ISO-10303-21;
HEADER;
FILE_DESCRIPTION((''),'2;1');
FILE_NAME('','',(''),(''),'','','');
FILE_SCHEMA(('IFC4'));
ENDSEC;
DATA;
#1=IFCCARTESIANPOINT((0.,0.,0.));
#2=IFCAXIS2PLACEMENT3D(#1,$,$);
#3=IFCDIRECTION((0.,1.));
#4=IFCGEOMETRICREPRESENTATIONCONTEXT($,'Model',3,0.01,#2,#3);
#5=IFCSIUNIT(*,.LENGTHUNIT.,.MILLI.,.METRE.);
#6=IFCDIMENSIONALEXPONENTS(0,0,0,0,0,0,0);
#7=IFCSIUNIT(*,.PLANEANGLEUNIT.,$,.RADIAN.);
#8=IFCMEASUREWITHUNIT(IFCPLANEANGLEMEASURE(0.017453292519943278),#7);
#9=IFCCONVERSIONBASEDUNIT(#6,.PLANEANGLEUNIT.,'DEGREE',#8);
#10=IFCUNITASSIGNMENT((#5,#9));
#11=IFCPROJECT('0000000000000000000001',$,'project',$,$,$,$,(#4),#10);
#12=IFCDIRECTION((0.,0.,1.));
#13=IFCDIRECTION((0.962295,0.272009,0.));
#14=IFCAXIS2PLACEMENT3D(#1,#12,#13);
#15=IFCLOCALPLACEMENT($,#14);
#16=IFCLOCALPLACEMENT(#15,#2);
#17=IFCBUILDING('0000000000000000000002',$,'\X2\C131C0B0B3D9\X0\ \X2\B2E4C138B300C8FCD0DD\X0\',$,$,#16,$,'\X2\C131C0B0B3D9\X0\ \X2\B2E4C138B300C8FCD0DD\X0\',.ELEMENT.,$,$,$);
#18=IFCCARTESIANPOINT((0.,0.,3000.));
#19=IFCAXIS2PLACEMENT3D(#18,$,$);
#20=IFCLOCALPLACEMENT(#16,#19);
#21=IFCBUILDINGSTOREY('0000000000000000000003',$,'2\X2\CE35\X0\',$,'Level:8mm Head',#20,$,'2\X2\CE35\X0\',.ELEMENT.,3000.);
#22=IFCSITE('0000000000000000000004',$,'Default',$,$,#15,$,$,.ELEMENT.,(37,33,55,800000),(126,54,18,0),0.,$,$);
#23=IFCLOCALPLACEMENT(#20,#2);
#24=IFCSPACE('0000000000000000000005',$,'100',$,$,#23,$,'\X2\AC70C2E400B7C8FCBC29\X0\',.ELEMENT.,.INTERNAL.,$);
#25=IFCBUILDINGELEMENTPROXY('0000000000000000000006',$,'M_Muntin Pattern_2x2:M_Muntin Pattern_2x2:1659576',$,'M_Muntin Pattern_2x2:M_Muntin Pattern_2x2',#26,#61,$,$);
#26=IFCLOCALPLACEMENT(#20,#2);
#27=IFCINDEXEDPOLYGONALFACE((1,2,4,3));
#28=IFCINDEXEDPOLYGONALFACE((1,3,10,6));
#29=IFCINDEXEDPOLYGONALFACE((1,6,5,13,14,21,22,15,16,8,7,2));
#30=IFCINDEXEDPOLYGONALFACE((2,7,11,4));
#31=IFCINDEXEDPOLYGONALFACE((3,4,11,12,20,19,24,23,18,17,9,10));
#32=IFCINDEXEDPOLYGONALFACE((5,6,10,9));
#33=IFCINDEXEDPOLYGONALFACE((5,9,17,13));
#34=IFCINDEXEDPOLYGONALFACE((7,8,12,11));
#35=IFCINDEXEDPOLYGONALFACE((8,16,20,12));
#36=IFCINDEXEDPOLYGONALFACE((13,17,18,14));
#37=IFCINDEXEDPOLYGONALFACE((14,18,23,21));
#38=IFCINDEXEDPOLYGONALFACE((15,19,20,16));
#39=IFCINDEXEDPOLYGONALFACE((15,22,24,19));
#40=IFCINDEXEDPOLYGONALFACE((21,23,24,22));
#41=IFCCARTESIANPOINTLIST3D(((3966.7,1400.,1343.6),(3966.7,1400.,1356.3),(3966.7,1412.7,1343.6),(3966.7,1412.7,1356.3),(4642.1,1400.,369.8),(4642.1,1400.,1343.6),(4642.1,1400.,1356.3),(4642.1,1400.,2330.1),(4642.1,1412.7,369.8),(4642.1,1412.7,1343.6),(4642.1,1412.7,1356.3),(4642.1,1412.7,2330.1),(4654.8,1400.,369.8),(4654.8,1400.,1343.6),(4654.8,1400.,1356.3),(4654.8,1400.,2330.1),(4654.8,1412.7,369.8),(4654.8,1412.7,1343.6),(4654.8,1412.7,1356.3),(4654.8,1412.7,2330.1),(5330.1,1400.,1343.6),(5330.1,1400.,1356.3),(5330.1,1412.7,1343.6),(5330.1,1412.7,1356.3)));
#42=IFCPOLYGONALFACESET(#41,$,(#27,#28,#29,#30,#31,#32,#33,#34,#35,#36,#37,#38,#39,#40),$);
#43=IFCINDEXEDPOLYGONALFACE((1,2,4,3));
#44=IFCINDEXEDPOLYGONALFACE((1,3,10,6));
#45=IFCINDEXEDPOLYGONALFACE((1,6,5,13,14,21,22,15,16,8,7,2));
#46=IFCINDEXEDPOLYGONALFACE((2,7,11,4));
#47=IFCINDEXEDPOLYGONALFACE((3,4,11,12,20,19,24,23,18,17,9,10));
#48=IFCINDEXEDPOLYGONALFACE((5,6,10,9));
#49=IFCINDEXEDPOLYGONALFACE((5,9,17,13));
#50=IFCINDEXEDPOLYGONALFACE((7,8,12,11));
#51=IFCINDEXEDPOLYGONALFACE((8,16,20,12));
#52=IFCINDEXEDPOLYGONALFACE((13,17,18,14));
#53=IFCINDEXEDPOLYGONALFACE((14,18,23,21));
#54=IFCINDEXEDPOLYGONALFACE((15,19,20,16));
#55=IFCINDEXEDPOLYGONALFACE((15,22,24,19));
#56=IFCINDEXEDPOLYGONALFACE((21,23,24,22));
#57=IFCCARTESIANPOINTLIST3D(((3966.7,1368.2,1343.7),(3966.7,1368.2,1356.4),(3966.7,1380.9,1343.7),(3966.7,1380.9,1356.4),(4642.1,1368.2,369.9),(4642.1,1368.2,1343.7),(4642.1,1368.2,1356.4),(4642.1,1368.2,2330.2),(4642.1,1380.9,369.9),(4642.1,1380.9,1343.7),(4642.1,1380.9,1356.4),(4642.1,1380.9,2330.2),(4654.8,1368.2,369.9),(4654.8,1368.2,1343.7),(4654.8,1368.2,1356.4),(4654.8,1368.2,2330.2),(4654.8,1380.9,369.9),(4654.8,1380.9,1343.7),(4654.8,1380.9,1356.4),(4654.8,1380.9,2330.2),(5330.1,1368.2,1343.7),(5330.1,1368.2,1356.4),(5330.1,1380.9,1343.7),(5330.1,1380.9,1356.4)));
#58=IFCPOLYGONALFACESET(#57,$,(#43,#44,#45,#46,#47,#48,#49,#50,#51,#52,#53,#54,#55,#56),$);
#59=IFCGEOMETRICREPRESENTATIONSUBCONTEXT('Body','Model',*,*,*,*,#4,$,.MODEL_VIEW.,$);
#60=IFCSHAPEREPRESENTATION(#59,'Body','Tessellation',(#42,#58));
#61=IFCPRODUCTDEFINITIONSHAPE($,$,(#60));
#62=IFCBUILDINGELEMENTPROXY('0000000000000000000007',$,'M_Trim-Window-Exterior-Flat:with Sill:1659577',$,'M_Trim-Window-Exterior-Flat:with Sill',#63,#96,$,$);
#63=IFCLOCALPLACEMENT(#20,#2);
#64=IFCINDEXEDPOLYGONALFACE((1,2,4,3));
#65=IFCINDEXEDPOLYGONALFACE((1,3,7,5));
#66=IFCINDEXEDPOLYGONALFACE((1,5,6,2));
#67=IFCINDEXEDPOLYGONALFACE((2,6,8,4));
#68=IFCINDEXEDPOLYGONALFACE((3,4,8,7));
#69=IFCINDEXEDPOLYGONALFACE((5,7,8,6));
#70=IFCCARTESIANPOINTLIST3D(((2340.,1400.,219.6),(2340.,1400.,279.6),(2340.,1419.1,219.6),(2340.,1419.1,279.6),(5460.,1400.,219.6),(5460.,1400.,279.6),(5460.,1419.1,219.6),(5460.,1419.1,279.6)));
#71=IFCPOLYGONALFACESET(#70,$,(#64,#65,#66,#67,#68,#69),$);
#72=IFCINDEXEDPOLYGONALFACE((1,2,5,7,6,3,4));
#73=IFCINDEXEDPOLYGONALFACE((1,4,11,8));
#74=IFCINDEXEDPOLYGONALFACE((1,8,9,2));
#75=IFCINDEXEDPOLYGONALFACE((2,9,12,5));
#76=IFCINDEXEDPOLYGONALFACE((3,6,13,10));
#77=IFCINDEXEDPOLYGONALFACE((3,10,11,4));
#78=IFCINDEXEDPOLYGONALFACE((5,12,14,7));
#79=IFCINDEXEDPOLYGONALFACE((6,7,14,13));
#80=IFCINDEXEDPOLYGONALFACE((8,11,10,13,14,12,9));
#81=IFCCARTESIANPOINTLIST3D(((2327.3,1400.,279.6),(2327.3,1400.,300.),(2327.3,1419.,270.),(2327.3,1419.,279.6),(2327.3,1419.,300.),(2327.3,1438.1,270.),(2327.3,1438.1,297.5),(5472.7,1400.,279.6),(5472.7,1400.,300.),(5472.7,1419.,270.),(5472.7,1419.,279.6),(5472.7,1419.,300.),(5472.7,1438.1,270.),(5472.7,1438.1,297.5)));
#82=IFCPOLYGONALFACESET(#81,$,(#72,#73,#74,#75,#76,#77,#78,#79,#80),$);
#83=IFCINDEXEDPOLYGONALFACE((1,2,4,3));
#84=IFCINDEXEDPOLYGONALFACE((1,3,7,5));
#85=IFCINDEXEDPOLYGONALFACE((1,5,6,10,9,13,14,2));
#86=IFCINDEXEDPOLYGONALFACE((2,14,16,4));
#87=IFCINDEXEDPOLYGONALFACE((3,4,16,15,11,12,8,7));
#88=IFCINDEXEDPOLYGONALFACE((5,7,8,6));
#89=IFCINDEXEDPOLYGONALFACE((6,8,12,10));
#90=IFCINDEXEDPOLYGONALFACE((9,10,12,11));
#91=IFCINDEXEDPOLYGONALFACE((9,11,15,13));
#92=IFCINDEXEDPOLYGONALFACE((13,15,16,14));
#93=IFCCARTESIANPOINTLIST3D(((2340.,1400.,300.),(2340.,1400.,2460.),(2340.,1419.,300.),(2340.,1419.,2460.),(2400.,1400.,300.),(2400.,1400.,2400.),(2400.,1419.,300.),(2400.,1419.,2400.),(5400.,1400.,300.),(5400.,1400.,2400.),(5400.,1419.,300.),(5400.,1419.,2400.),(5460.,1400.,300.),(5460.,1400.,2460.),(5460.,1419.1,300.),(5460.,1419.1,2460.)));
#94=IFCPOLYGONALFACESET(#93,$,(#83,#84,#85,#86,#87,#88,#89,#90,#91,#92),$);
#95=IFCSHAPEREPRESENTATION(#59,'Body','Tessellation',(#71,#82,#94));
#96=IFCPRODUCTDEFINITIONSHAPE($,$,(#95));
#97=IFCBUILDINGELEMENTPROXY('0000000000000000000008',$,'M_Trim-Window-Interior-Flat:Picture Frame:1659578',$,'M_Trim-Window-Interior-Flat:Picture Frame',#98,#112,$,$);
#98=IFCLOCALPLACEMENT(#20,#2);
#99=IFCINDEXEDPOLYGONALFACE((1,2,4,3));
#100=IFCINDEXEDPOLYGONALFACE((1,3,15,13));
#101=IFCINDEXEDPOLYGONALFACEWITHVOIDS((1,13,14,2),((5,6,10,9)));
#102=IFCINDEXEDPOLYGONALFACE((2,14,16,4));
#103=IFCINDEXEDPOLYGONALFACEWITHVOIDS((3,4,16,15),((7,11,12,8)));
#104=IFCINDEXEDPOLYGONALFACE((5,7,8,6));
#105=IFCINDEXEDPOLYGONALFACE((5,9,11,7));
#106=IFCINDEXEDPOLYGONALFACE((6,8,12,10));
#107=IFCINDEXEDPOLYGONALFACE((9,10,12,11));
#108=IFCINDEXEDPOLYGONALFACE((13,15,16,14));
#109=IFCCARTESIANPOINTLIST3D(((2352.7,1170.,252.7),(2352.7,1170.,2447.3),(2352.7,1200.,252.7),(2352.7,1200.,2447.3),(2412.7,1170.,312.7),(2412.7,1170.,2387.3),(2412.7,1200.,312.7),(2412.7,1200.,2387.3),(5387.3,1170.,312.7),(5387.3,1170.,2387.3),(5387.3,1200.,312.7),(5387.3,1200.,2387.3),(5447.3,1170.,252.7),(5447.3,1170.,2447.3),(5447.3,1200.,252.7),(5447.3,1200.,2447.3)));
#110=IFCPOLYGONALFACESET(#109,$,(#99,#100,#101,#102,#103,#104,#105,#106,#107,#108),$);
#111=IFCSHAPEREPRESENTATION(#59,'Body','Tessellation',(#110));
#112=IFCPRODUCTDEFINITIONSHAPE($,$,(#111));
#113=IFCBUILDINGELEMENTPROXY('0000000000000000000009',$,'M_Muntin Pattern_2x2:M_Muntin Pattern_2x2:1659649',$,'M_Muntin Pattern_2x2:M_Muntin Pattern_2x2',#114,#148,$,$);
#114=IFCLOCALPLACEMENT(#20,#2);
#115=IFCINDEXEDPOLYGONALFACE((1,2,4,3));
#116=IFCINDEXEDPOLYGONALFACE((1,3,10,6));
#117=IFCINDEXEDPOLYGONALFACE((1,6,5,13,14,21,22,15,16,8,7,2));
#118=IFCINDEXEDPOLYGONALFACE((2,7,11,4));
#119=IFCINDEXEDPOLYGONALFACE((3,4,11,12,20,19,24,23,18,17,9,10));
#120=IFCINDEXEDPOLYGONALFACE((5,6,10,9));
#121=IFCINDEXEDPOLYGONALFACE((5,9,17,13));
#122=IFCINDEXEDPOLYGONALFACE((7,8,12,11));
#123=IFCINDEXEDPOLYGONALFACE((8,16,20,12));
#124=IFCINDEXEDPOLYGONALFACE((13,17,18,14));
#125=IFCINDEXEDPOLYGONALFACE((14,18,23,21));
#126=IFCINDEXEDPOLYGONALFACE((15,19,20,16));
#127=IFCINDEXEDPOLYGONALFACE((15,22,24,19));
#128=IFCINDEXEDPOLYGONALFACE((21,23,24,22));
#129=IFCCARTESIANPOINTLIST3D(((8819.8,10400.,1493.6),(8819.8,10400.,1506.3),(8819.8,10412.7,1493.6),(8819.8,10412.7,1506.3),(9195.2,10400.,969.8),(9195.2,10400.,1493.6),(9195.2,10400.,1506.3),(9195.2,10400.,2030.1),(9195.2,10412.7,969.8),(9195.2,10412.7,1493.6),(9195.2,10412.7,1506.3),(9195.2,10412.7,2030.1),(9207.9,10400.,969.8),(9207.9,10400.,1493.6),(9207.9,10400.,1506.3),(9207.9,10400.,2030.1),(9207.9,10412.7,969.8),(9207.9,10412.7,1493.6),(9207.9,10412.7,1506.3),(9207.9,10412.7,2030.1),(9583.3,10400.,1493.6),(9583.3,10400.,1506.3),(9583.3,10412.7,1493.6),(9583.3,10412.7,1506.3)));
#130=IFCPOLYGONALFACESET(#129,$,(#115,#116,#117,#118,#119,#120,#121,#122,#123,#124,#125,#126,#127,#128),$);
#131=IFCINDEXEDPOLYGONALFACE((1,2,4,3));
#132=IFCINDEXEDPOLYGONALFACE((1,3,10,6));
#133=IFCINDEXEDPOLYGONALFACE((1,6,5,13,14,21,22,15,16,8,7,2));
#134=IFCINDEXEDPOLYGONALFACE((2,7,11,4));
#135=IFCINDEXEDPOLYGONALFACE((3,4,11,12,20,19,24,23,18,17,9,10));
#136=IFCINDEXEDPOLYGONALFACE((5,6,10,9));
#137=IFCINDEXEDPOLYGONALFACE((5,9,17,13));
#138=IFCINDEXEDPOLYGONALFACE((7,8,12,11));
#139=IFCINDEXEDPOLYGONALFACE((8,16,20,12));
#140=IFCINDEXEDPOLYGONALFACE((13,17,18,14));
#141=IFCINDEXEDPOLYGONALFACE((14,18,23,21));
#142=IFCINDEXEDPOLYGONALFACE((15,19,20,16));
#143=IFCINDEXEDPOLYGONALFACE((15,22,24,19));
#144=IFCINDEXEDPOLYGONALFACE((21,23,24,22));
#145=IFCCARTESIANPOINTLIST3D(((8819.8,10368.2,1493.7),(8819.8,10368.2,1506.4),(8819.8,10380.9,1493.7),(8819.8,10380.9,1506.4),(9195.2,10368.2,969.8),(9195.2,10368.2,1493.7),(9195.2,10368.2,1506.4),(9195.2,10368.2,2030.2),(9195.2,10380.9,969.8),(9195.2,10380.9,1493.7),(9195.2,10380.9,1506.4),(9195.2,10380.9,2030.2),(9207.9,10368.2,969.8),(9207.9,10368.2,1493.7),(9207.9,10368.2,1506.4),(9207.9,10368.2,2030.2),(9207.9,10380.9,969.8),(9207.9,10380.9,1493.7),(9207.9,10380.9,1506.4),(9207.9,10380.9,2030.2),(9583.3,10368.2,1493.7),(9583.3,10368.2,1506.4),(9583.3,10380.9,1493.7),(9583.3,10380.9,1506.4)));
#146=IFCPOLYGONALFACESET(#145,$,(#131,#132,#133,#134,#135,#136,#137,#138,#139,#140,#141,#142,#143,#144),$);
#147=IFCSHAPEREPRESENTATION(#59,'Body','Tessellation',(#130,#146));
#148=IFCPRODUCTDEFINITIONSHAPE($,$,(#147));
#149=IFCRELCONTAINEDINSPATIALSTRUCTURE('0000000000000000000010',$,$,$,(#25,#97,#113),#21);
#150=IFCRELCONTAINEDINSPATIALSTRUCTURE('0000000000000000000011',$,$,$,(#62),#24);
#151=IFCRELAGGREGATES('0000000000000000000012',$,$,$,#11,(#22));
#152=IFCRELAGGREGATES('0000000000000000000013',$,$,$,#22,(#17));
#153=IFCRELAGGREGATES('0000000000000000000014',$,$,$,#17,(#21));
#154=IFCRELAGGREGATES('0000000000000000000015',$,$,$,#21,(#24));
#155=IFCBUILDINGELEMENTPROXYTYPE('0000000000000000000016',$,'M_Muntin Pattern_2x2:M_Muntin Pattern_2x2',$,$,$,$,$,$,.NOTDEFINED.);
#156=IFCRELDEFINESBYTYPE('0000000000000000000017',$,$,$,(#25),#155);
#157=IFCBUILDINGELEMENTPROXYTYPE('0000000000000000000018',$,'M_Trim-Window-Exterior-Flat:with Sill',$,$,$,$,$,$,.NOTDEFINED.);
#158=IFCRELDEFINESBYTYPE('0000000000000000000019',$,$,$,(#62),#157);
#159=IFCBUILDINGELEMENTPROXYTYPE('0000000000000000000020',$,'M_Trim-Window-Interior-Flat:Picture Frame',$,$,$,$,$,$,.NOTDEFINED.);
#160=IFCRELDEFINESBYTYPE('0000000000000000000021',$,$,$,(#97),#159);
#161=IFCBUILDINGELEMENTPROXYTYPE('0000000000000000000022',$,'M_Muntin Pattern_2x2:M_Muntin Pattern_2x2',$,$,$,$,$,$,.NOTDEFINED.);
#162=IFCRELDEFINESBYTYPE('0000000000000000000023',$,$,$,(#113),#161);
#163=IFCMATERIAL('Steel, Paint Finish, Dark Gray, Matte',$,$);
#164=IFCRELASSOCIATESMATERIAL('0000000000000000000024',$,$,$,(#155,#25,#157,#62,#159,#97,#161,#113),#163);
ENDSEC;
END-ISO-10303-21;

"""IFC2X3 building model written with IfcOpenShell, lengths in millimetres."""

from ifc_helpers import new_model, entity, si_unit, converted_unit, direction, frame, frame_2d, origin, place, context, subcontext, project, spatial, polyline, rectangle, outline, extrude, source, transform, mapped, material, type_object, type_shapes, element, save


model = new_model("IFC2X3")

# Units and contexts
model_context = context("Model", 3, precision=0.01, world=origin(), true_north=direction((0.0, 1.0)))
body_context = subcontext(model_context, "Body", "Model", "MODEL_VIEW")
ifc_project = project(units=[si_unit("LENGTHUNIT", "METRE", prefix="MILLI"), converted_unit("PLANEANGLEUNIT", "DEGREE", entity("IfcPlaneAngleMeasure", 0.017453292519943278), si_unit("PLANEANGLEUNIT", "RADIAN"), dimensions=[0, 0, 0, 0, 0, 0, 0])], contexts=[model_context])

# Site, building, storey
site_placement = place(None, frame((0.0, 0.0, 0.0), z_axis=(0.0, 0.0, 1.0), x_axis=(0.962295, 0.272009, 0.0)))
site = spatial("IfcSite", under=ifc_project, at=site_placement, Name="Default", CompositionType="ELEMENT", RefLatitude=(37, 33, 55, 800000), RefLongitude=(126, 54, 18, 0), RefElevation=0.0)
building_placement = place(site_placement, origin())
building = spatial("IfcBuilding", under=site, at=building_placement, Name="성산동 다세대주택", LongName="성산동 다세대주택", CompositionType="ELEMENT")
storey_placement = place(building_placement, frame((0.0, 0.0, 3000.0)))
storey = spatial("IfcBuildingStorey", under=building, at=storey_placement, Name="2층", ObjectType="Level:8mm Head", LongName="2층", CompositionType="ELEMENT", Elevation=3000.0)

# Shared definitions
space_1_placement = place(storey_placement, origin())
space_1 = spatial("IfcSpace", under=storey, at=space_1_placement, Name="100", LongName="거실·주방", CompositionType="ELEMENT", InteriorOrExteriorSpace="INTERNAL")

# Building element proxies
ifc_material_1 = material(Name="Steel, Paint Finish, Dark Gray, Matte")
building_element_proxy_type_1 = type_object("IfcBuildingElementProxyType", Name="M_Muntin Pattern_2x2:M_Muntin Pattern_2x2", PredefinedType="NOTDEFINED", material=ifc_material_1)
shared_shape_1 = source(origin(), body_context, "Body", "SweptSolid", [
    extrude(outline(polyline([(6.4, -6.4), (980.1, -6.4), (980.1, 6.3), (6.4, 6.3), (6.4, 681.7), (-6.3, 681.7), (-6.3, 6.3), (-980.2, 6.3), (-980.2, -6.4), (-6.3, -6.4), (-6.3, -681.7), (6.4, -681.7), (6.4, -6.4)])), frame((0.0, -22.2, 980.1), z_axis=(0.0, 1.0, 0.0), x_axis=(0.0, 0.0, 1.0)), (0.0, 0.0, 1.0), 12.7),
    extrude(outline(polyline([(6.4, -6.4), (980.2, -6.4), (980.2, 6.3), (6.4, 6.3), (6.4, 681.7), (-6.3, 681.7), (-6.3, 6.3), (-980.2, 6.3), (-980.2, -6.4), (-6.3, -6.4), (-6.3, -681.7), (6.4, -681.7), (6.4, -6.4)])), frame((0.0, 9.5, 980.2), z_axis=(0.0, 1.0, 0.0), x_axis=(0.0, 0.0, 1.0)), (0.0, 0.0, 1.0), 12.7),
])
type_shapes(building_element_proxy_type_1, [shared_shape_1])
proxy_1_placement = place(storey_placement, frame((4648.4, 1390.5, 369.9), z_axis=(0.0, 0.0, 1.0), x_axis=(-1.0, 0.0, 0.0)))
element("IfcBuildingElementProxy", 1, at=proxy_1_placement, inside=storey, type_object=building_element_proxy_type_1, material=ifc_material_1, Name="M_Muntin Pattern_2x2:M_Muntin Pattern_2x2:1659576", ObjectType="M_Muntin Pattern_2x2:M_Muntin Pattern_2x2", context=body_context, shape_type="MappedRepresentation", body=[
    mapped(shared_shape_1, transform((0.0, 0.0, 0.0), scale=1.0)),
])
building_element_proxy_type_2 = type_object("IfcBuildingElementProxyType", Name="M_Trim-Window-Exterior-Flat:with Sill", PredefinedType="NOTDEFINED", material=ifc_material_1)
shared_shape_2 = source(origin(), body_context, "Body", "SweptSolid", [
    extrude(rectangle(XDim=3120.0, YDim=60.0, at=frame_2d((0.0, 0.0), x_axis=(1.0, 0.0))), frame((0.0, -2150.4, 0.0), z_axis=(0.0, 0.0, 1.0), x_axis=(-1.0, 0.0, 0.0)), (0.0, 0.0, 1.0), 19.0),
    extrude(outline(polyline([(-19.0, -15.2), (0.0, -15.2), (0.0, -5.7), (19.0, -5.7), (19.0, 14.8), (0.0, 14.8), (-19.0, 12.3), (-19.0, -15.2)])), frame((-1572.7, -2114.8, 19.0), z_axis=(1.0, 0.0, 0.0), x_axis=(0.0, 0.0, -1.0)), (0.0, 0.0, 1.0), 3145.4),
    extrude(outline(polyline([(-1095.0, -1560.0), (1065.0, -1560.0), (1065.0, -1500.0), (-1035.0, -1500.0), (-1035.0, 1500.0), (1065.0, 1500.0), (1065.0, 1560.0), (-1095.0, 1560.0), (-1095.0, -1560.0)])), frame((0.0, -1035.0, 0.0), z_axis=(0.0, 0.0, 1.0), x_axis=(0.0, -1.0, 0.0)), (0.0, 0.0, 1.0), 19.0),
])
type_shapes(building_element_proxy_type_2, [shared_shape_2])
proxy_2_placement = place(space_1_placement, frame((3900.0, 1400.0, 2400.0), z_axis=(0.0, 1.0, 0.0), x_axis=(-1.0, 0.0, 0.0)))
element("IfcBuildingElementProxy", 2, at=proxy_2_placement, inside=space_1, type_object=building_element_proxy_type_2, material=ifc_material_1, Name="M_Trim-Window-Exterior-Flat:with Sill:1659577", ObjectType="M_Trim-Window-Exterior-Flat:with Sill", context=body_context, shape_type="MappedRepresentation", body=[
    mapped(shared_shape_2, transform((0.0, 0.0, 0.0), scale=1.0)),
])
building_element_proxy_type_3 = type_object("IfcBuildingElementProxyType", Name="M_Trim-Window-Interior-Flat:Picture Frame", PredefinedType="NOTDEFINED", material=ifc_material_1)
shared_shape_3 = source(origin(), body_context, "Body", "SweptSolid", [
    extrude(outline(polyline([(-1547.3, -1097.3), (1547.3, -1097.3), (1547.3, 1097.3), (-1547.3, 1097.3), (-1547.3, -1097.3)]), holes=[polyline([(-1487.3, -1037.3), (-1487.3, 1037.3), (1487.3, 1037.3), (1487.3, -1037.3), (-1487.3, -1037.3)])]), frame((0.0, -1050.0, 0.0), z_axis=(0.0, 0.0, 1.0), x_axis=(-1.0, 0.0, 0.0)), (0.0, 0.0, 1.0), 30.0),
])
type_shapes(building_element_proxy_type_3, [shared_shape_3])
proxy_3_placement = place(storey_placement, frame((3900.0, 1200.0, 2400.0), z_axis=(0.0, -1.0, 0.0), x_axis=(1.0, 0.0, 0.0)))
element("IfcBuildingElementProxy", 3, at=proxy_3_placement, inside=storey, type_object=building_element_proxy_type_3, material=ifc_material_1, Name="M_Trim-Window-Interior-Flat:Picture Frame:1659578", ObjectType="M_Trim-Window-Interior-Flat:Picture Frame", context=body_context, shape_type="MappedRepresentation", body=[
    mapped(shared_shape_3, transform((0.0, 0.0, 0.0), scale=1.0)),
])
building_element_proxy_type_4 = type_object("IfcBuildingElementProxyType", Name="M_Muntin Pattern_2x2:M_Muntin Pattern_2x2", PredefinedType="NOTDEFINED", material=ifc_material_1)
shared_shape_4 = source(origin(), body_context, "Body", "SweptSolid", [
    extrude(outline(polyline([(6.4, -6.4), (530.1, -6.4), (530.1, 6.3), (6.4, 6.3), (6.4, 381.7), (-6.3, 381.7), (-6.3, 6.3), (-530.2, 6.3), (-530.2, -6.4), (-6.3, -6.4), (-6.3, -381.7), (6.4, -381.7), (6.4, -6.4)])), frame((0.0, 9.5, 530.1), z_axis=(0.0, 1.0, 0.0), x_axis=(0.0, 0.0, 1.0)), (0.0, 0.0, 1.0), 12.7),
    extrude(outline(polyline([(6.4, -6.4), (530.2, -6.4), (530.2, 6.3), (6.4, 6.3), (6.4, 381.7), (-6.3, 381.7), (-6.3, 6.3), (-530.2, 6.3), (-530.2, -6.4), (-6.3, -6.4), (-6.3, -381.7), (6.4, -381.7), (6.4, -6.4)])), frame((0.0, -22.2, 530.2), z_axis=(0.0, 1.0, 0.0), x_axis=(0.0, 0.0, 1.0)), (0.0, 0.0, 1.0), 12.7),
])
type_shapes(building_element_proxy_type_4, [shared_shape_4])
proxy_4_placement = place(storey_placement, frame((9201.6, 10390.5, 969.8)))
element("IfcBuildingElementProxy", 4, at=proxy_4_placement, inside=storey, type_object=building_element_proxy_type_4, material=ifc_material_1, Name="M_Muntin Pattern_2x2:M_Muntin Pattern_2x2:1659649", ObjectType="M_Muntin Pattern_2x2:M_Muntin Pattern_2x2", context=body_context, shape_type="MappedRepresentation", body=[
    mapped(shared_shape_4, transform((0.0, 0.0, 0.0), scale=1.0)),
])

save(model, "model.ifc")
